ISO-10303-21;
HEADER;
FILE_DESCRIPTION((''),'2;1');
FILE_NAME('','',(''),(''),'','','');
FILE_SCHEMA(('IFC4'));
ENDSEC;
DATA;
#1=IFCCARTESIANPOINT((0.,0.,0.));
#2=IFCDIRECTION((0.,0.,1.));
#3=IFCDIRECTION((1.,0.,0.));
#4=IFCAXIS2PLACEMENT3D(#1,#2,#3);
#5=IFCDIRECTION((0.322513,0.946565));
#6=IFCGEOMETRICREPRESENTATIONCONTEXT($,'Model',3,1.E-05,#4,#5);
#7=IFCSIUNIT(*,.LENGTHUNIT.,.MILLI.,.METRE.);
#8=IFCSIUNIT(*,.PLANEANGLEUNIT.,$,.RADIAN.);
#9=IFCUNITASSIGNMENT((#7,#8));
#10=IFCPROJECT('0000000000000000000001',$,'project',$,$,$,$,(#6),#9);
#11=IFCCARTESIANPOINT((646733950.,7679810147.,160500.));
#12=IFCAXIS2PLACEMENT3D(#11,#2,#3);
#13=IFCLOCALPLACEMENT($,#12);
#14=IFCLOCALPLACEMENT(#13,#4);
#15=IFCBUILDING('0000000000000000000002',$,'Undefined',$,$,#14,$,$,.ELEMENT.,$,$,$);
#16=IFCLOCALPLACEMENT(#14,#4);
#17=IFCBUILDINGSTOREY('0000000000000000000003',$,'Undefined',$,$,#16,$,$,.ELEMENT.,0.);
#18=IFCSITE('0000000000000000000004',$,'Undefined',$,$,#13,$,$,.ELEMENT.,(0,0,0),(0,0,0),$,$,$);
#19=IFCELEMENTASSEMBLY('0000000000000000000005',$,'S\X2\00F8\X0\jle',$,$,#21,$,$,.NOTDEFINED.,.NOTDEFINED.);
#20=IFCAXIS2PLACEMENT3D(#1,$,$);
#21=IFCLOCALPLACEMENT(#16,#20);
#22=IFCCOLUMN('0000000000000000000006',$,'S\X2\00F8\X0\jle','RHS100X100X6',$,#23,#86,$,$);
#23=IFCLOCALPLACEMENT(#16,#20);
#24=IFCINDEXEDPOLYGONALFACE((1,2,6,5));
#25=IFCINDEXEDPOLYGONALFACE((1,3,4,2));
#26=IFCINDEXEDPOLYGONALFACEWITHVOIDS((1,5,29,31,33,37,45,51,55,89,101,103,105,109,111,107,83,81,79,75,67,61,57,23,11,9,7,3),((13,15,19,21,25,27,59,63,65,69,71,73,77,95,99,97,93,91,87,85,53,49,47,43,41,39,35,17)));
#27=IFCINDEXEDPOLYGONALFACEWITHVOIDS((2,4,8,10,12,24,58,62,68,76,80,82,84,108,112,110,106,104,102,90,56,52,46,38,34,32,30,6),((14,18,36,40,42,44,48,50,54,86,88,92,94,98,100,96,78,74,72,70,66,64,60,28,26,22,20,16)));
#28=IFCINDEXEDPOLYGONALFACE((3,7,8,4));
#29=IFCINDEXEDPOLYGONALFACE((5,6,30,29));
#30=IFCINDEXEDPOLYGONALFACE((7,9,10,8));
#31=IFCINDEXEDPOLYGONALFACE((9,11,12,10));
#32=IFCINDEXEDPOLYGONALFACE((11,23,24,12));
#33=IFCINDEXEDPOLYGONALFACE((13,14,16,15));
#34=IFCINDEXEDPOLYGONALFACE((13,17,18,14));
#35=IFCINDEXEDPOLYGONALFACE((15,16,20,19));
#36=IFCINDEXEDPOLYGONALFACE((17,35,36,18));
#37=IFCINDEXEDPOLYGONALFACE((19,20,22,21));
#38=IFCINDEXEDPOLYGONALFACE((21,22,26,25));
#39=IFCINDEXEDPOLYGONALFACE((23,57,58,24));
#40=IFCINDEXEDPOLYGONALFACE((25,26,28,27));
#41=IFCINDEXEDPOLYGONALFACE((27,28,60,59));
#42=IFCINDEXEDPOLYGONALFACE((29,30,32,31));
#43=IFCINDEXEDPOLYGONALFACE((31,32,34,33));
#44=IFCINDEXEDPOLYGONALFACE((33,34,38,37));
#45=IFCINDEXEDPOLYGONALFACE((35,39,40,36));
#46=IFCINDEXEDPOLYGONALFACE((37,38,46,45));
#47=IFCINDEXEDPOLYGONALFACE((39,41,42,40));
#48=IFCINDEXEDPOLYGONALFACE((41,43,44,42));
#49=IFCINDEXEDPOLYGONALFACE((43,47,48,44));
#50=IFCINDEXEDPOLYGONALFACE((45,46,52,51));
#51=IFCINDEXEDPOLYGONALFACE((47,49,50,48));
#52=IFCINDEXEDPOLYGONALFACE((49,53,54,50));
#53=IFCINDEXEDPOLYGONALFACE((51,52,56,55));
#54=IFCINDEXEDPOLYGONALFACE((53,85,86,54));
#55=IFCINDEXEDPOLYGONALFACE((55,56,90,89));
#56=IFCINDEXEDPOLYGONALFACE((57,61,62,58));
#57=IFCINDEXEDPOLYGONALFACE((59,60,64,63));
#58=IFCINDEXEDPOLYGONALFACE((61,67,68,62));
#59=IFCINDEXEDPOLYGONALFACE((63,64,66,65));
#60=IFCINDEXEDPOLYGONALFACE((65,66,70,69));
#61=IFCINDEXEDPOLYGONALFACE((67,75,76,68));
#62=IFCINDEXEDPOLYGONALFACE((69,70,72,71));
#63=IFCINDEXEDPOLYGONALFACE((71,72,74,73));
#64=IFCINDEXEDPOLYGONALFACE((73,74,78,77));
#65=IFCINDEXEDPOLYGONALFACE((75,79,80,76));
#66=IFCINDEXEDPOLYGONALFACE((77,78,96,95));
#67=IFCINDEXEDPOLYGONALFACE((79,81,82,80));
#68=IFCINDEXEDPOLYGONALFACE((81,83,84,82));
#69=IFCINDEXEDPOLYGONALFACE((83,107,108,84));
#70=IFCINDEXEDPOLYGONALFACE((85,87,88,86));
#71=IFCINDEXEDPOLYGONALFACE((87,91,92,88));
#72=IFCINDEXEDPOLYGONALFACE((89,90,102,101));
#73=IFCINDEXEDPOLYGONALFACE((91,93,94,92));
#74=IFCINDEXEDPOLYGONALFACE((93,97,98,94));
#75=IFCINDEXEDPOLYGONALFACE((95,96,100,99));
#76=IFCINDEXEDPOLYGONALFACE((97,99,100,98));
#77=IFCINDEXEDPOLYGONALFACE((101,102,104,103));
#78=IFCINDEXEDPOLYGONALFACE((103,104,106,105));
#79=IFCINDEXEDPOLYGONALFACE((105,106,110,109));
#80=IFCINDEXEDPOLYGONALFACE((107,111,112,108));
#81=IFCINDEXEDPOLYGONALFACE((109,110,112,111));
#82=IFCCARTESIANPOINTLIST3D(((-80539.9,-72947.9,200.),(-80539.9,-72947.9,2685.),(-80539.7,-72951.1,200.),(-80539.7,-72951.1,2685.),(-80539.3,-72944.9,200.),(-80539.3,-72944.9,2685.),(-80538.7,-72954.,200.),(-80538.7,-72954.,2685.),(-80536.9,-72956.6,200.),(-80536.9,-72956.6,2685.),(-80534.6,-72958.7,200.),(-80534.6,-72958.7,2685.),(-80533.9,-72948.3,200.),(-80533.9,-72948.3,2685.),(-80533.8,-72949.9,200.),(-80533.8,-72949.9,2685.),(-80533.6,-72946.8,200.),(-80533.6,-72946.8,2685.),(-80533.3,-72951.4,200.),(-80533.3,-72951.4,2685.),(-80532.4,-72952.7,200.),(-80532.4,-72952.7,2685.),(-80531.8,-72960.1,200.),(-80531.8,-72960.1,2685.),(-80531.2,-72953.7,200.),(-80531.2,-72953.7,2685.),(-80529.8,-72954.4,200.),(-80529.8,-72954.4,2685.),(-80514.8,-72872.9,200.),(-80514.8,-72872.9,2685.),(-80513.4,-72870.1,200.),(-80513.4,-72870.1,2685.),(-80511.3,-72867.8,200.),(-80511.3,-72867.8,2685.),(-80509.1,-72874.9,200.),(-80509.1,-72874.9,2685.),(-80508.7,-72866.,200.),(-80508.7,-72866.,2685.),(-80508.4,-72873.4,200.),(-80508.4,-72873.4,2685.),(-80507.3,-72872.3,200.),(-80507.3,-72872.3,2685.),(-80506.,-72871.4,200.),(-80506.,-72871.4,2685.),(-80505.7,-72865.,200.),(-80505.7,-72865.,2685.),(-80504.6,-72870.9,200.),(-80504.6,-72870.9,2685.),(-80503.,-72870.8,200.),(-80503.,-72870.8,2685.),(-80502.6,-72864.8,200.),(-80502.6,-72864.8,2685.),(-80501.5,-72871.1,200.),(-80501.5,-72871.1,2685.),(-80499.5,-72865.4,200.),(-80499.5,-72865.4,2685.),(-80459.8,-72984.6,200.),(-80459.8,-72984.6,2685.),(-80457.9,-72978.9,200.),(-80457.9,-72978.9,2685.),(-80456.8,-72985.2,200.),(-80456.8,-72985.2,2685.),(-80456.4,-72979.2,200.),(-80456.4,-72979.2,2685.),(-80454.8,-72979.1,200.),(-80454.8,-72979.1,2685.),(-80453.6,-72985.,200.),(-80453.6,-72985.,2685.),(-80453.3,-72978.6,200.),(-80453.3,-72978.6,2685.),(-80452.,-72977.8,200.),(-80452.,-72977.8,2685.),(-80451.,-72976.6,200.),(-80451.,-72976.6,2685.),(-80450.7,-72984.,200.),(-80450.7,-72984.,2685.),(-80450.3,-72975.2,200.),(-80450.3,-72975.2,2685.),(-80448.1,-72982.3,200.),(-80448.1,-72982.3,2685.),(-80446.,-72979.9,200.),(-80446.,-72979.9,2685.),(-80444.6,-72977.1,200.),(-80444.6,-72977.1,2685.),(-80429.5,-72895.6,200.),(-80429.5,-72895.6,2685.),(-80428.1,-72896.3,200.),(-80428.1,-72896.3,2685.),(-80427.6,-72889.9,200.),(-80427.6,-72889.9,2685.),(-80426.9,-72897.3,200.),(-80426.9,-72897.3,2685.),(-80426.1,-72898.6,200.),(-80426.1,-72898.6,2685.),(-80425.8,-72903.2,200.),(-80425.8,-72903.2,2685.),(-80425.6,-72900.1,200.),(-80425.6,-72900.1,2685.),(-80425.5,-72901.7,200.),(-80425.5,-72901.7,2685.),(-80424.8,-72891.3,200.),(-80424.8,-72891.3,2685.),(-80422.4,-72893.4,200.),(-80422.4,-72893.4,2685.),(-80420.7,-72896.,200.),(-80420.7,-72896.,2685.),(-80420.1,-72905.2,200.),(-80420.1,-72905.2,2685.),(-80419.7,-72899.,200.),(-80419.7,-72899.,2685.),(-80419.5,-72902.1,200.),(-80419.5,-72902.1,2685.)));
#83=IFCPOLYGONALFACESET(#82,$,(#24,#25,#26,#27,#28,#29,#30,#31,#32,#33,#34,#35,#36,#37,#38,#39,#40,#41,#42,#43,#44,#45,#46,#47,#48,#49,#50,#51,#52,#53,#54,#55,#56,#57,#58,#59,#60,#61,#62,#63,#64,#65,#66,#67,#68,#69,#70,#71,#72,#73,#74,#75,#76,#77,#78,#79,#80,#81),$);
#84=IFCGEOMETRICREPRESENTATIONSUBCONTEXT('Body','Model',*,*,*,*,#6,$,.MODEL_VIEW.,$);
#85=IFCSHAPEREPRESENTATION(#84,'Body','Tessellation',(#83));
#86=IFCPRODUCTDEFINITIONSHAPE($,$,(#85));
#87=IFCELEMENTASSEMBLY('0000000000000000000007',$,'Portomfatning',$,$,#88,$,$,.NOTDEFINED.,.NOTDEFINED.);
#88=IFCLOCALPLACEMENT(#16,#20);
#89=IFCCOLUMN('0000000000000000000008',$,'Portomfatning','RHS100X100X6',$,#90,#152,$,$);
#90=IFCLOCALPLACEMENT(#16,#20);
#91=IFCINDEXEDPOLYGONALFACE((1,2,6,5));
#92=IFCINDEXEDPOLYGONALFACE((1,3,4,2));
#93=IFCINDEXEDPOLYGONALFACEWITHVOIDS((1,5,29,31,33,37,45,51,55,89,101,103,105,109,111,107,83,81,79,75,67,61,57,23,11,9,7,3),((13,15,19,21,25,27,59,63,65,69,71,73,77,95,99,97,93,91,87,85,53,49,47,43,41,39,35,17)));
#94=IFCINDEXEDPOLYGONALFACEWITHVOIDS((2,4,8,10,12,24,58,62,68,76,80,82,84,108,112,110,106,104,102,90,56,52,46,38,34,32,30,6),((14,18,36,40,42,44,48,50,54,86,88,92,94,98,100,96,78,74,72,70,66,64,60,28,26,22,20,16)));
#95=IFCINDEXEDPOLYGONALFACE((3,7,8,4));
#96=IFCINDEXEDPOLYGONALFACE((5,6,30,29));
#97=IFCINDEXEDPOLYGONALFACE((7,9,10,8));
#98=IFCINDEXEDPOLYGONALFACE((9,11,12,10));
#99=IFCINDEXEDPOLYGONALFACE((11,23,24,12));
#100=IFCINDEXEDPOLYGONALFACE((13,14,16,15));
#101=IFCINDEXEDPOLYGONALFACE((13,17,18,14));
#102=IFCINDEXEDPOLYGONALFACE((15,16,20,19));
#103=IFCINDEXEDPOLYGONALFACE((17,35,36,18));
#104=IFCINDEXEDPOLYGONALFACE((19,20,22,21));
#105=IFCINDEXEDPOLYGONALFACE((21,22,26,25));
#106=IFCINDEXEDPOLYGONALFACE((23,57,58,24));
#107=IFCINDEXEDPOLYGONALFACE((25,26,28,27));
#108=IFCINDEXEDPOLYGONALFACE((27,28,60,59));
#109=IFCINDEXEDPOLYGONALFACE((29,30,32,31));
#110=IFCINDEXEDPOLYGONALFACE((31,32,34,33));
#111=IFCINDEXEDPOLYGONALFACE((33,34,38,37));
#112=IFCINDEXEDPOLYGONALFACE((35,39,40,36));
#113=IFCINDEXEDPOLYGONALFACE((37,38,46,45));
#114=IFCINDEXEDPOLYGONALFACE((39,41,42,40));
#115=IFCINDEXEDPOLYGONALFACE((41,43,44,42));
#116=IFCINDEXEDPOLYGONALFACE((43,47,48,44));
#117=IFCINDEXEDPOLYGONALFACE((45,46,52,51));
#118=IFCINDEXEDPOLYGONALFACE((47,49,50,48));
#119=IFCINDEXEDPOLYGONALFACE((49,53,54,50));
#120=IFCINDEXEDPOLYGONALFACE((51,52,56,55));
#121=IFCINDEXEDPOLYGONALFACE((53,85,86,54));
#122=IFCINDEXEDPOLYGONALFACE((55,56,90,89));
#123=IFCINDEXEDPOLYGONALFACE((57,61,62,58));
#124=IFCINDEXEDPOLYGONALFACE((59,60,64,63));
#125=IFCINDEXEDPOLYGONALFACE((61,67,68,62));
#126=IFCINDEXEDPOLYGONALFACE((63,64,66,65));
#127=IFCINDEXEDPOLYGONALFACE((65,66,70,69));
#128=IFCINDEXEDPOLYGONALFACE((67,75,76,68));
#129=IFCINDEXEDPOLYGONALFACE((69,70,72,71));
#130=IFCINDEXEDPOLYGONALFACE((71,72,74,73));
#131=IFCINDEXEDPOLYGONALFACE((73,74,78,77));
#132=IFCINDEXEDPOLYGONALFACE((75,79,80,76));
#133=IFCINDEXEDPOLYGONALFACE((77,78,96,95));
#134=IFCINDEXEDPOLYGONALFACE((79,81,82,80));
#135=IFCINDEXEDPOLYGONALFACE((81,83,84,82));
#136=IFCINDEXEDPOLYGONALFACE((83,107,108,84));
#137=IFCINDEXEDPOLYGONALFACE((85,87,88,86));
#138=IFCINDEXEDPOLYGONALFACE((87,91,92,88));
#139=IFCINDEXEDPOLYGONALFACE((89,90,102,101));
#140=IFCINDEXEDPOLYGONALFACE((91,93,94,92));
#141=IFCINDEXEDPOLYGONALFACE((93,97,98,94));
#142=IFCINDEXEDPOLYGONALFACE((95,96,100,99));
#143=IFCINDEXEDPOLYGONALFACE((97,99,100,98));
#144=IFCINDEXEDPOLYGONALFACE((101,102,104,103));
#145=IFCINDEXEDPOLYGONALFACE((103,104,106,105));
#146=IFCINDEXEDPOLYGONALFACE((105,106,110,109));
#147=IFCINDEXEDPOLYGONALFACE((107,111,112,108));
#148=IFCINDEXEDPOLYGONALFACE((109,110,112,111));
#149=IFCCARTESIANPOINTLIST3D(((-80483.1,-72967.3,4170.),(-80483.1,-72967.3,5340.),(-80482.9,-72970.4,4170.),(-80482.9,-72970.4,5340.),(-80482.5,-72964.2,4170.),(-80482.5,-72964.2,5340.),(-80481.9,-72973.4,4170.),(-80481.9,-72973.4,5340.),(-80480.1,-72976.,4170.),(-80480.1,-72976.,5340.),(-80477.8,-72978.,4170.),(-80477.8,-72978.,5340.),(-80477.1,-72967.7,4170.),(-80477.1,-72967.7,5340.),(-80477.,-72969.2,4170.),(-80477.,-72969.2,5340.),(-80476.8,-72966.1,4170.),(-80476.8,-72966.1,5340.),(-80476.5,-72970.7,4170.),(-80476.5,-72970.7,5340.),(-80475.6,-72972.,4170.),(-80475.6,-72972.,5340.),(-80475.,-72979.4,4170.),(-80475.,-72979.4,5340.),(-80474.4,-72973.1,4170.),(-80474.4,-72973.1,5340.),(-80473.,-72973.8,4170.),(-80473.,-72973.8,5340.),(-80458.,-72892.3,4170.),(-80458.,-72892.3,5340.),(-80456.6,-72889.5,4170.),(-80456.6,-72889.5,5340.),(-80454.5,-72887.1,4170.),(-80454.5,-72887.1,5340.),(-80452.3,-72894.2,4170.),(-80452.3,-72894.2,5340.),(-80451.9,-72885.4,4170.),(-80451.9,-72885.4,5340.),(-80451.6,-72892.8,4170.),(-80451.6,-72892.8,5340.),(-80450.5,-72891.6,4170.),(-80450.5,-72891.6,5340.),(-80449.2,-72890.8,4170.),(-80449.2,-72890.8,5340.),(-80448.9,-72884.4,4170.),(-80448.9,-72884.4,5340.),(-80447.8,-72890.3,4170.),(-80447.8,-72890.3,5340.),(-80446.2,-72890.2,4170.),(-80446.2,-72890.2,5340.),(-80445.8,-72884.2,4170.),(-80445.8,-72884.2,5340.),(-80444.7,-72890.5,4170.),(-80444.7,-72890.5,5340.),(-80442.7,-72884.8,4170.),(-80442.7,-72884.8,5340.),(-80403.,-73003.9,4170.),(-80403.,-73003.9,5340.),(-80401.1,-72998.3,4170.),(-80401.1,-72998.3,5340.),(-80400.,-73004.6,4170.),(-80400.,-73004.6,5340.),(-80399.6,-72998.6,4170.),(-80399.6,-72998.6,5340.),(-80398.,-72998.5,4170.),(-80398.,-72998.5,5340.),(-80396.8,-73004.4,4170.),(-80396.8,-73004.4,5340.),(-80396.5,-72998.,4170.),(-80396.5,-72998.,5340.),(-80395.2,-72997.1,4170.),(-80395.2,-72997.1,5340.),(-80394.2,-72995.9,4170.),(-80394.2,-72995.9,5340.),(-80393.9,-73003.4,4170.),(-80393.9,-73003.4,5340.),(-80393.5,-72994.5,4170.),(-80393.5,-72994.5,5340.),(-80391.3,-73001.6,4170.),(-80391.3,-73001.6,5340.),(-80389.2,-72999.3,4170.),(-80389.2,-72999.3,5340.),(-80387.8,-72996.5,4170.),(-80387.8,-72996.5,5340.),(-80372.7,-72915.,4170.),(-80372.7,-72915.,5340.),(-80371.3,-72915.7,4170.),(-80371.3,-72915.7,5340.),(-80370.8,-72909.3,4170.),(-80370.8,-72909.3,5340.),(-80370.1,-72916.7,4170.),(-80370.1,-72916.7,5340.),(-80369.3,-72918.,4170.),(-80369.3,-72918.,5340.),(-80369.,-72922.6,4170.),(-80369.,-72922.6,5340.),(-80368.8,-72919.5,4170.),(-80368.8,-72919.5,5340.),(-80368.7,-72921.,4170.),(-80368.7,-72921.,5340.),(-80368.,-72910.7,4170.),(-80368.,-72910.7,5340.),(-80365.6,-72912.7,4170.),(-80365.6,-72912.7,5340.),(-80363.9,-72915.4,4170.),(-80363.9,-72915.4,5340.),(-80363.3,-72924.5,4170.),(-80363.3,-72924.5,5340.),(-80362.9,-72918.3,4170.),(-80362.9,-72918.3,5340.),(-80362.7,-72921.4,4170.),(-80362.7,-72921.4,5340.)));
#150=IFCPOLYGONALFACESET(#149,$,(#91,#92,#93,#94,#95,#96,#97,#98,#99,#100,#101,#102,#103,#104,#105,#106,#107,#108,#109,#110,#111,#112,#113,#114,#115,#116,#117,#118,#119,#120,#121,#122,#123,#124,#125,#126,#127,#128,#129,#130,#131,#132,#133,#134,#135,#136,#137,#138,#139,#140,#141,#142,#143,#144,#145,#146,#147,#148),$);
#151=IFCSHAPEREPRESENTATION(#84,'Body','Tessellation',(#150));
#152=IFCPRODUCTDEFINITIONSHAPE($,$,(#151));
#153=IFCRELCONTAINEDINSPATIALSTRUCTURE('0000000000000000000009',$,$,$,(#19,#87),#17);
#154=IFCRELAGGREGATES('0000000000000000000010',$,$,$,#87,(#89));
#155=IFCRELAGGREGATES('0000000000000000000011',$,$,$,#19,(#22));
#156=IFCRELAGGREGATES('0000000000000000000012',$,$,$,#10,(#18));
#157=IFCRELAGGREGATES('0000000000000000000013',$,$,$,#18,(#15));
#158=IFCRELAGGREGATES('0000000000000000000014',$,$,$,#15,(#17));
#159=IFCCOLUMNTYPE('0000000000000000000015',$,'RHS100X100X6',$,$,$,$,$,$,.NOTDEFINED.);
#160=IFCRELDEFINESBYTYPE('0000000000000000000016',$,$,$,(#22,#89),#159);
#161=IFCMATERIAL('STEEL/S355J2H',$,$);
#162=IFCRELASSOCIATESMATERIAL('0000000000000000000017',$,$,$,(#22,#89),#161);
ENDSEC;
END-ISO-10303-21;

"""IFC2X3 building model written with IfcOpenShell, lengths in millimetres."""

from ifc_helpers import new_model, si_unit, direction, frame, origin_with_axes, origin_2d_with_axis, place, context, subcontext, project, spatial, hollow_rectangle, extrude, clip, halfspace, material, type_object, element, aggregate, save


model = new_model("IFC2X3")

# Units and contexts
model_context = context("Model", 3, precision=1e-05, world=origin_with_axes(), true_north=direction((0.322513, 0.946565)))
body_context = subcontext(model_context, "Body", "Model", "MODEL_VIEW")
ifc_project = project(units=[si_unit("LENGTHUNIT", "METRE", prefix="MILLI"), si_unit("PLANEANGLEUNIT", "RADIAN")], contexts=[model_context])

# Site, building, storey
site_placement = place(None, frame((646733950.0, 7679810147.0, 160500.0), z_axis=(0.0, 0.0, 1.0), x_axis=(1.0, 0.0, 0.0)))
site = spatial("IfcSite", under=ifc_project, at=site_placement, Name="Undefined", CompositionType="ELEMENT", RefLatitude=(0, 0, 0), RefLongitude=(0, 0, 0))
building_placement = place(site_placement, origin_with_axes())
building = spatial("IfcBuilding", under=site, at=building_placement, Name="Undefined", CompositionType="ELEMENT")
storey_placement = place(building_placement, origin_with_axes())
storey = spatial("IfcBuildingStorey", under=building, at=storey_placement, Name="Undefined", CompositionType="ELEMENT", Elevation=0.0)

# Element assemblies, columns
assembly_1_placement = place(storey_placement, origin_with_axes())
assembly_1 = element("IfcElementAssembly", 1, at=assembly_1_placement, inside=storey, Name="Søjle", AssemblyPlace="NOTDEFINED", PredefinedType="NOTDEFINED")
ifc_material_1 = material(Name="STEEL/S355J2H")
column_type = type_object("IfcColumnType", Name="RHS100X100X6", PredefinedType="NOTDEFINED")
column_1_placement = place(assembly_1_placement, frame((-80479.7, -72925.0, 200.0), z_axis=(0.0, 0.0, 1.0), x_axis=(-0.322513, -0.946565, 0.0)))
column_1 = element("IfcColumn", 2, at=column_1_placement, type_object=column_type, material=ifc_material_1, Name="Søjle", Description="RHS100X100X6", context=body_context, shape_type="Clipping", body=[
    clip(extrude(hollow_rectangle(XDim=100.0, YDim=100.0, WallThickness=6.0, InnerFilletRadius=6.0, OuterFilletRadius=12.0, at=origin_2d_with_axis()), frame((0.0, 0.0, 2495.0), z_axis=(0.0, 0.0, -1.0), x_axis=(0.0, 1.0, 0.0)), (0.0, 0.0, 1.0), 2495.0), halfspace(frame((-50.0, 0.0, 2485.0), z_axis=(0.0, 0.0, -1.0), x_axis=(0.0, -1.0, 0.0)), True)),
])
assembly_2_placement = place(storey_placement, origin_with_axes())
assembly_2 = element("IfcElementAssembly", 3, at=assembly_2_placement, inside=storey, Name="Portomfatning", AssemblyPlace="NOTDEFINED", PredefinedType="NOTDEFINED")
column_2_placement = place(assembly_2_placement, frame((-80422.9, -72944.4, 4160.0), z_axis=(0.0, 0.0, 1.0), x_axis=(-0.322513, -0.946565, 0.0)))
column_2 = element("IfcColumn", 4, at=column_2_placement, type_object=column_type, material=ifc_material_1, Name="Portomfatning", Description="RHS100X100X6", context=body_context, shape_type="Clipping", body=[
    clip(clip(extrude(hollow_rectangle(XDim=100.0, YDim=100.0, WallThickness=6.0, InnerFilletRadius=6.0, OuterFilletRadius=12.0, at=origin_2d_with_axis()), frame((0.0, 0.0, 1190.0), z_axis=(0.0, 0.0, -1.0), x_axis=(0.0, 1.0, 0.0)), (0.0, 0.0, 1.0), 1190.0), halfspace(frame((0.0, -50.0, 1180.0), z_axis=(0.0, 0.0, -1.0), x_axis=(1.0, 0.0, 0.0)), True)), halfspace(frame((0.0, -50.0, 10.0), z_axis=(0.0, 0.0, 1.0), x_axis=(-1.0, 0.0, 0.0)), True)),
])

aggregate(assembly_2, [column_2])
aggregate(assembly_1, [column_1])

save(model, "model.ifc")
